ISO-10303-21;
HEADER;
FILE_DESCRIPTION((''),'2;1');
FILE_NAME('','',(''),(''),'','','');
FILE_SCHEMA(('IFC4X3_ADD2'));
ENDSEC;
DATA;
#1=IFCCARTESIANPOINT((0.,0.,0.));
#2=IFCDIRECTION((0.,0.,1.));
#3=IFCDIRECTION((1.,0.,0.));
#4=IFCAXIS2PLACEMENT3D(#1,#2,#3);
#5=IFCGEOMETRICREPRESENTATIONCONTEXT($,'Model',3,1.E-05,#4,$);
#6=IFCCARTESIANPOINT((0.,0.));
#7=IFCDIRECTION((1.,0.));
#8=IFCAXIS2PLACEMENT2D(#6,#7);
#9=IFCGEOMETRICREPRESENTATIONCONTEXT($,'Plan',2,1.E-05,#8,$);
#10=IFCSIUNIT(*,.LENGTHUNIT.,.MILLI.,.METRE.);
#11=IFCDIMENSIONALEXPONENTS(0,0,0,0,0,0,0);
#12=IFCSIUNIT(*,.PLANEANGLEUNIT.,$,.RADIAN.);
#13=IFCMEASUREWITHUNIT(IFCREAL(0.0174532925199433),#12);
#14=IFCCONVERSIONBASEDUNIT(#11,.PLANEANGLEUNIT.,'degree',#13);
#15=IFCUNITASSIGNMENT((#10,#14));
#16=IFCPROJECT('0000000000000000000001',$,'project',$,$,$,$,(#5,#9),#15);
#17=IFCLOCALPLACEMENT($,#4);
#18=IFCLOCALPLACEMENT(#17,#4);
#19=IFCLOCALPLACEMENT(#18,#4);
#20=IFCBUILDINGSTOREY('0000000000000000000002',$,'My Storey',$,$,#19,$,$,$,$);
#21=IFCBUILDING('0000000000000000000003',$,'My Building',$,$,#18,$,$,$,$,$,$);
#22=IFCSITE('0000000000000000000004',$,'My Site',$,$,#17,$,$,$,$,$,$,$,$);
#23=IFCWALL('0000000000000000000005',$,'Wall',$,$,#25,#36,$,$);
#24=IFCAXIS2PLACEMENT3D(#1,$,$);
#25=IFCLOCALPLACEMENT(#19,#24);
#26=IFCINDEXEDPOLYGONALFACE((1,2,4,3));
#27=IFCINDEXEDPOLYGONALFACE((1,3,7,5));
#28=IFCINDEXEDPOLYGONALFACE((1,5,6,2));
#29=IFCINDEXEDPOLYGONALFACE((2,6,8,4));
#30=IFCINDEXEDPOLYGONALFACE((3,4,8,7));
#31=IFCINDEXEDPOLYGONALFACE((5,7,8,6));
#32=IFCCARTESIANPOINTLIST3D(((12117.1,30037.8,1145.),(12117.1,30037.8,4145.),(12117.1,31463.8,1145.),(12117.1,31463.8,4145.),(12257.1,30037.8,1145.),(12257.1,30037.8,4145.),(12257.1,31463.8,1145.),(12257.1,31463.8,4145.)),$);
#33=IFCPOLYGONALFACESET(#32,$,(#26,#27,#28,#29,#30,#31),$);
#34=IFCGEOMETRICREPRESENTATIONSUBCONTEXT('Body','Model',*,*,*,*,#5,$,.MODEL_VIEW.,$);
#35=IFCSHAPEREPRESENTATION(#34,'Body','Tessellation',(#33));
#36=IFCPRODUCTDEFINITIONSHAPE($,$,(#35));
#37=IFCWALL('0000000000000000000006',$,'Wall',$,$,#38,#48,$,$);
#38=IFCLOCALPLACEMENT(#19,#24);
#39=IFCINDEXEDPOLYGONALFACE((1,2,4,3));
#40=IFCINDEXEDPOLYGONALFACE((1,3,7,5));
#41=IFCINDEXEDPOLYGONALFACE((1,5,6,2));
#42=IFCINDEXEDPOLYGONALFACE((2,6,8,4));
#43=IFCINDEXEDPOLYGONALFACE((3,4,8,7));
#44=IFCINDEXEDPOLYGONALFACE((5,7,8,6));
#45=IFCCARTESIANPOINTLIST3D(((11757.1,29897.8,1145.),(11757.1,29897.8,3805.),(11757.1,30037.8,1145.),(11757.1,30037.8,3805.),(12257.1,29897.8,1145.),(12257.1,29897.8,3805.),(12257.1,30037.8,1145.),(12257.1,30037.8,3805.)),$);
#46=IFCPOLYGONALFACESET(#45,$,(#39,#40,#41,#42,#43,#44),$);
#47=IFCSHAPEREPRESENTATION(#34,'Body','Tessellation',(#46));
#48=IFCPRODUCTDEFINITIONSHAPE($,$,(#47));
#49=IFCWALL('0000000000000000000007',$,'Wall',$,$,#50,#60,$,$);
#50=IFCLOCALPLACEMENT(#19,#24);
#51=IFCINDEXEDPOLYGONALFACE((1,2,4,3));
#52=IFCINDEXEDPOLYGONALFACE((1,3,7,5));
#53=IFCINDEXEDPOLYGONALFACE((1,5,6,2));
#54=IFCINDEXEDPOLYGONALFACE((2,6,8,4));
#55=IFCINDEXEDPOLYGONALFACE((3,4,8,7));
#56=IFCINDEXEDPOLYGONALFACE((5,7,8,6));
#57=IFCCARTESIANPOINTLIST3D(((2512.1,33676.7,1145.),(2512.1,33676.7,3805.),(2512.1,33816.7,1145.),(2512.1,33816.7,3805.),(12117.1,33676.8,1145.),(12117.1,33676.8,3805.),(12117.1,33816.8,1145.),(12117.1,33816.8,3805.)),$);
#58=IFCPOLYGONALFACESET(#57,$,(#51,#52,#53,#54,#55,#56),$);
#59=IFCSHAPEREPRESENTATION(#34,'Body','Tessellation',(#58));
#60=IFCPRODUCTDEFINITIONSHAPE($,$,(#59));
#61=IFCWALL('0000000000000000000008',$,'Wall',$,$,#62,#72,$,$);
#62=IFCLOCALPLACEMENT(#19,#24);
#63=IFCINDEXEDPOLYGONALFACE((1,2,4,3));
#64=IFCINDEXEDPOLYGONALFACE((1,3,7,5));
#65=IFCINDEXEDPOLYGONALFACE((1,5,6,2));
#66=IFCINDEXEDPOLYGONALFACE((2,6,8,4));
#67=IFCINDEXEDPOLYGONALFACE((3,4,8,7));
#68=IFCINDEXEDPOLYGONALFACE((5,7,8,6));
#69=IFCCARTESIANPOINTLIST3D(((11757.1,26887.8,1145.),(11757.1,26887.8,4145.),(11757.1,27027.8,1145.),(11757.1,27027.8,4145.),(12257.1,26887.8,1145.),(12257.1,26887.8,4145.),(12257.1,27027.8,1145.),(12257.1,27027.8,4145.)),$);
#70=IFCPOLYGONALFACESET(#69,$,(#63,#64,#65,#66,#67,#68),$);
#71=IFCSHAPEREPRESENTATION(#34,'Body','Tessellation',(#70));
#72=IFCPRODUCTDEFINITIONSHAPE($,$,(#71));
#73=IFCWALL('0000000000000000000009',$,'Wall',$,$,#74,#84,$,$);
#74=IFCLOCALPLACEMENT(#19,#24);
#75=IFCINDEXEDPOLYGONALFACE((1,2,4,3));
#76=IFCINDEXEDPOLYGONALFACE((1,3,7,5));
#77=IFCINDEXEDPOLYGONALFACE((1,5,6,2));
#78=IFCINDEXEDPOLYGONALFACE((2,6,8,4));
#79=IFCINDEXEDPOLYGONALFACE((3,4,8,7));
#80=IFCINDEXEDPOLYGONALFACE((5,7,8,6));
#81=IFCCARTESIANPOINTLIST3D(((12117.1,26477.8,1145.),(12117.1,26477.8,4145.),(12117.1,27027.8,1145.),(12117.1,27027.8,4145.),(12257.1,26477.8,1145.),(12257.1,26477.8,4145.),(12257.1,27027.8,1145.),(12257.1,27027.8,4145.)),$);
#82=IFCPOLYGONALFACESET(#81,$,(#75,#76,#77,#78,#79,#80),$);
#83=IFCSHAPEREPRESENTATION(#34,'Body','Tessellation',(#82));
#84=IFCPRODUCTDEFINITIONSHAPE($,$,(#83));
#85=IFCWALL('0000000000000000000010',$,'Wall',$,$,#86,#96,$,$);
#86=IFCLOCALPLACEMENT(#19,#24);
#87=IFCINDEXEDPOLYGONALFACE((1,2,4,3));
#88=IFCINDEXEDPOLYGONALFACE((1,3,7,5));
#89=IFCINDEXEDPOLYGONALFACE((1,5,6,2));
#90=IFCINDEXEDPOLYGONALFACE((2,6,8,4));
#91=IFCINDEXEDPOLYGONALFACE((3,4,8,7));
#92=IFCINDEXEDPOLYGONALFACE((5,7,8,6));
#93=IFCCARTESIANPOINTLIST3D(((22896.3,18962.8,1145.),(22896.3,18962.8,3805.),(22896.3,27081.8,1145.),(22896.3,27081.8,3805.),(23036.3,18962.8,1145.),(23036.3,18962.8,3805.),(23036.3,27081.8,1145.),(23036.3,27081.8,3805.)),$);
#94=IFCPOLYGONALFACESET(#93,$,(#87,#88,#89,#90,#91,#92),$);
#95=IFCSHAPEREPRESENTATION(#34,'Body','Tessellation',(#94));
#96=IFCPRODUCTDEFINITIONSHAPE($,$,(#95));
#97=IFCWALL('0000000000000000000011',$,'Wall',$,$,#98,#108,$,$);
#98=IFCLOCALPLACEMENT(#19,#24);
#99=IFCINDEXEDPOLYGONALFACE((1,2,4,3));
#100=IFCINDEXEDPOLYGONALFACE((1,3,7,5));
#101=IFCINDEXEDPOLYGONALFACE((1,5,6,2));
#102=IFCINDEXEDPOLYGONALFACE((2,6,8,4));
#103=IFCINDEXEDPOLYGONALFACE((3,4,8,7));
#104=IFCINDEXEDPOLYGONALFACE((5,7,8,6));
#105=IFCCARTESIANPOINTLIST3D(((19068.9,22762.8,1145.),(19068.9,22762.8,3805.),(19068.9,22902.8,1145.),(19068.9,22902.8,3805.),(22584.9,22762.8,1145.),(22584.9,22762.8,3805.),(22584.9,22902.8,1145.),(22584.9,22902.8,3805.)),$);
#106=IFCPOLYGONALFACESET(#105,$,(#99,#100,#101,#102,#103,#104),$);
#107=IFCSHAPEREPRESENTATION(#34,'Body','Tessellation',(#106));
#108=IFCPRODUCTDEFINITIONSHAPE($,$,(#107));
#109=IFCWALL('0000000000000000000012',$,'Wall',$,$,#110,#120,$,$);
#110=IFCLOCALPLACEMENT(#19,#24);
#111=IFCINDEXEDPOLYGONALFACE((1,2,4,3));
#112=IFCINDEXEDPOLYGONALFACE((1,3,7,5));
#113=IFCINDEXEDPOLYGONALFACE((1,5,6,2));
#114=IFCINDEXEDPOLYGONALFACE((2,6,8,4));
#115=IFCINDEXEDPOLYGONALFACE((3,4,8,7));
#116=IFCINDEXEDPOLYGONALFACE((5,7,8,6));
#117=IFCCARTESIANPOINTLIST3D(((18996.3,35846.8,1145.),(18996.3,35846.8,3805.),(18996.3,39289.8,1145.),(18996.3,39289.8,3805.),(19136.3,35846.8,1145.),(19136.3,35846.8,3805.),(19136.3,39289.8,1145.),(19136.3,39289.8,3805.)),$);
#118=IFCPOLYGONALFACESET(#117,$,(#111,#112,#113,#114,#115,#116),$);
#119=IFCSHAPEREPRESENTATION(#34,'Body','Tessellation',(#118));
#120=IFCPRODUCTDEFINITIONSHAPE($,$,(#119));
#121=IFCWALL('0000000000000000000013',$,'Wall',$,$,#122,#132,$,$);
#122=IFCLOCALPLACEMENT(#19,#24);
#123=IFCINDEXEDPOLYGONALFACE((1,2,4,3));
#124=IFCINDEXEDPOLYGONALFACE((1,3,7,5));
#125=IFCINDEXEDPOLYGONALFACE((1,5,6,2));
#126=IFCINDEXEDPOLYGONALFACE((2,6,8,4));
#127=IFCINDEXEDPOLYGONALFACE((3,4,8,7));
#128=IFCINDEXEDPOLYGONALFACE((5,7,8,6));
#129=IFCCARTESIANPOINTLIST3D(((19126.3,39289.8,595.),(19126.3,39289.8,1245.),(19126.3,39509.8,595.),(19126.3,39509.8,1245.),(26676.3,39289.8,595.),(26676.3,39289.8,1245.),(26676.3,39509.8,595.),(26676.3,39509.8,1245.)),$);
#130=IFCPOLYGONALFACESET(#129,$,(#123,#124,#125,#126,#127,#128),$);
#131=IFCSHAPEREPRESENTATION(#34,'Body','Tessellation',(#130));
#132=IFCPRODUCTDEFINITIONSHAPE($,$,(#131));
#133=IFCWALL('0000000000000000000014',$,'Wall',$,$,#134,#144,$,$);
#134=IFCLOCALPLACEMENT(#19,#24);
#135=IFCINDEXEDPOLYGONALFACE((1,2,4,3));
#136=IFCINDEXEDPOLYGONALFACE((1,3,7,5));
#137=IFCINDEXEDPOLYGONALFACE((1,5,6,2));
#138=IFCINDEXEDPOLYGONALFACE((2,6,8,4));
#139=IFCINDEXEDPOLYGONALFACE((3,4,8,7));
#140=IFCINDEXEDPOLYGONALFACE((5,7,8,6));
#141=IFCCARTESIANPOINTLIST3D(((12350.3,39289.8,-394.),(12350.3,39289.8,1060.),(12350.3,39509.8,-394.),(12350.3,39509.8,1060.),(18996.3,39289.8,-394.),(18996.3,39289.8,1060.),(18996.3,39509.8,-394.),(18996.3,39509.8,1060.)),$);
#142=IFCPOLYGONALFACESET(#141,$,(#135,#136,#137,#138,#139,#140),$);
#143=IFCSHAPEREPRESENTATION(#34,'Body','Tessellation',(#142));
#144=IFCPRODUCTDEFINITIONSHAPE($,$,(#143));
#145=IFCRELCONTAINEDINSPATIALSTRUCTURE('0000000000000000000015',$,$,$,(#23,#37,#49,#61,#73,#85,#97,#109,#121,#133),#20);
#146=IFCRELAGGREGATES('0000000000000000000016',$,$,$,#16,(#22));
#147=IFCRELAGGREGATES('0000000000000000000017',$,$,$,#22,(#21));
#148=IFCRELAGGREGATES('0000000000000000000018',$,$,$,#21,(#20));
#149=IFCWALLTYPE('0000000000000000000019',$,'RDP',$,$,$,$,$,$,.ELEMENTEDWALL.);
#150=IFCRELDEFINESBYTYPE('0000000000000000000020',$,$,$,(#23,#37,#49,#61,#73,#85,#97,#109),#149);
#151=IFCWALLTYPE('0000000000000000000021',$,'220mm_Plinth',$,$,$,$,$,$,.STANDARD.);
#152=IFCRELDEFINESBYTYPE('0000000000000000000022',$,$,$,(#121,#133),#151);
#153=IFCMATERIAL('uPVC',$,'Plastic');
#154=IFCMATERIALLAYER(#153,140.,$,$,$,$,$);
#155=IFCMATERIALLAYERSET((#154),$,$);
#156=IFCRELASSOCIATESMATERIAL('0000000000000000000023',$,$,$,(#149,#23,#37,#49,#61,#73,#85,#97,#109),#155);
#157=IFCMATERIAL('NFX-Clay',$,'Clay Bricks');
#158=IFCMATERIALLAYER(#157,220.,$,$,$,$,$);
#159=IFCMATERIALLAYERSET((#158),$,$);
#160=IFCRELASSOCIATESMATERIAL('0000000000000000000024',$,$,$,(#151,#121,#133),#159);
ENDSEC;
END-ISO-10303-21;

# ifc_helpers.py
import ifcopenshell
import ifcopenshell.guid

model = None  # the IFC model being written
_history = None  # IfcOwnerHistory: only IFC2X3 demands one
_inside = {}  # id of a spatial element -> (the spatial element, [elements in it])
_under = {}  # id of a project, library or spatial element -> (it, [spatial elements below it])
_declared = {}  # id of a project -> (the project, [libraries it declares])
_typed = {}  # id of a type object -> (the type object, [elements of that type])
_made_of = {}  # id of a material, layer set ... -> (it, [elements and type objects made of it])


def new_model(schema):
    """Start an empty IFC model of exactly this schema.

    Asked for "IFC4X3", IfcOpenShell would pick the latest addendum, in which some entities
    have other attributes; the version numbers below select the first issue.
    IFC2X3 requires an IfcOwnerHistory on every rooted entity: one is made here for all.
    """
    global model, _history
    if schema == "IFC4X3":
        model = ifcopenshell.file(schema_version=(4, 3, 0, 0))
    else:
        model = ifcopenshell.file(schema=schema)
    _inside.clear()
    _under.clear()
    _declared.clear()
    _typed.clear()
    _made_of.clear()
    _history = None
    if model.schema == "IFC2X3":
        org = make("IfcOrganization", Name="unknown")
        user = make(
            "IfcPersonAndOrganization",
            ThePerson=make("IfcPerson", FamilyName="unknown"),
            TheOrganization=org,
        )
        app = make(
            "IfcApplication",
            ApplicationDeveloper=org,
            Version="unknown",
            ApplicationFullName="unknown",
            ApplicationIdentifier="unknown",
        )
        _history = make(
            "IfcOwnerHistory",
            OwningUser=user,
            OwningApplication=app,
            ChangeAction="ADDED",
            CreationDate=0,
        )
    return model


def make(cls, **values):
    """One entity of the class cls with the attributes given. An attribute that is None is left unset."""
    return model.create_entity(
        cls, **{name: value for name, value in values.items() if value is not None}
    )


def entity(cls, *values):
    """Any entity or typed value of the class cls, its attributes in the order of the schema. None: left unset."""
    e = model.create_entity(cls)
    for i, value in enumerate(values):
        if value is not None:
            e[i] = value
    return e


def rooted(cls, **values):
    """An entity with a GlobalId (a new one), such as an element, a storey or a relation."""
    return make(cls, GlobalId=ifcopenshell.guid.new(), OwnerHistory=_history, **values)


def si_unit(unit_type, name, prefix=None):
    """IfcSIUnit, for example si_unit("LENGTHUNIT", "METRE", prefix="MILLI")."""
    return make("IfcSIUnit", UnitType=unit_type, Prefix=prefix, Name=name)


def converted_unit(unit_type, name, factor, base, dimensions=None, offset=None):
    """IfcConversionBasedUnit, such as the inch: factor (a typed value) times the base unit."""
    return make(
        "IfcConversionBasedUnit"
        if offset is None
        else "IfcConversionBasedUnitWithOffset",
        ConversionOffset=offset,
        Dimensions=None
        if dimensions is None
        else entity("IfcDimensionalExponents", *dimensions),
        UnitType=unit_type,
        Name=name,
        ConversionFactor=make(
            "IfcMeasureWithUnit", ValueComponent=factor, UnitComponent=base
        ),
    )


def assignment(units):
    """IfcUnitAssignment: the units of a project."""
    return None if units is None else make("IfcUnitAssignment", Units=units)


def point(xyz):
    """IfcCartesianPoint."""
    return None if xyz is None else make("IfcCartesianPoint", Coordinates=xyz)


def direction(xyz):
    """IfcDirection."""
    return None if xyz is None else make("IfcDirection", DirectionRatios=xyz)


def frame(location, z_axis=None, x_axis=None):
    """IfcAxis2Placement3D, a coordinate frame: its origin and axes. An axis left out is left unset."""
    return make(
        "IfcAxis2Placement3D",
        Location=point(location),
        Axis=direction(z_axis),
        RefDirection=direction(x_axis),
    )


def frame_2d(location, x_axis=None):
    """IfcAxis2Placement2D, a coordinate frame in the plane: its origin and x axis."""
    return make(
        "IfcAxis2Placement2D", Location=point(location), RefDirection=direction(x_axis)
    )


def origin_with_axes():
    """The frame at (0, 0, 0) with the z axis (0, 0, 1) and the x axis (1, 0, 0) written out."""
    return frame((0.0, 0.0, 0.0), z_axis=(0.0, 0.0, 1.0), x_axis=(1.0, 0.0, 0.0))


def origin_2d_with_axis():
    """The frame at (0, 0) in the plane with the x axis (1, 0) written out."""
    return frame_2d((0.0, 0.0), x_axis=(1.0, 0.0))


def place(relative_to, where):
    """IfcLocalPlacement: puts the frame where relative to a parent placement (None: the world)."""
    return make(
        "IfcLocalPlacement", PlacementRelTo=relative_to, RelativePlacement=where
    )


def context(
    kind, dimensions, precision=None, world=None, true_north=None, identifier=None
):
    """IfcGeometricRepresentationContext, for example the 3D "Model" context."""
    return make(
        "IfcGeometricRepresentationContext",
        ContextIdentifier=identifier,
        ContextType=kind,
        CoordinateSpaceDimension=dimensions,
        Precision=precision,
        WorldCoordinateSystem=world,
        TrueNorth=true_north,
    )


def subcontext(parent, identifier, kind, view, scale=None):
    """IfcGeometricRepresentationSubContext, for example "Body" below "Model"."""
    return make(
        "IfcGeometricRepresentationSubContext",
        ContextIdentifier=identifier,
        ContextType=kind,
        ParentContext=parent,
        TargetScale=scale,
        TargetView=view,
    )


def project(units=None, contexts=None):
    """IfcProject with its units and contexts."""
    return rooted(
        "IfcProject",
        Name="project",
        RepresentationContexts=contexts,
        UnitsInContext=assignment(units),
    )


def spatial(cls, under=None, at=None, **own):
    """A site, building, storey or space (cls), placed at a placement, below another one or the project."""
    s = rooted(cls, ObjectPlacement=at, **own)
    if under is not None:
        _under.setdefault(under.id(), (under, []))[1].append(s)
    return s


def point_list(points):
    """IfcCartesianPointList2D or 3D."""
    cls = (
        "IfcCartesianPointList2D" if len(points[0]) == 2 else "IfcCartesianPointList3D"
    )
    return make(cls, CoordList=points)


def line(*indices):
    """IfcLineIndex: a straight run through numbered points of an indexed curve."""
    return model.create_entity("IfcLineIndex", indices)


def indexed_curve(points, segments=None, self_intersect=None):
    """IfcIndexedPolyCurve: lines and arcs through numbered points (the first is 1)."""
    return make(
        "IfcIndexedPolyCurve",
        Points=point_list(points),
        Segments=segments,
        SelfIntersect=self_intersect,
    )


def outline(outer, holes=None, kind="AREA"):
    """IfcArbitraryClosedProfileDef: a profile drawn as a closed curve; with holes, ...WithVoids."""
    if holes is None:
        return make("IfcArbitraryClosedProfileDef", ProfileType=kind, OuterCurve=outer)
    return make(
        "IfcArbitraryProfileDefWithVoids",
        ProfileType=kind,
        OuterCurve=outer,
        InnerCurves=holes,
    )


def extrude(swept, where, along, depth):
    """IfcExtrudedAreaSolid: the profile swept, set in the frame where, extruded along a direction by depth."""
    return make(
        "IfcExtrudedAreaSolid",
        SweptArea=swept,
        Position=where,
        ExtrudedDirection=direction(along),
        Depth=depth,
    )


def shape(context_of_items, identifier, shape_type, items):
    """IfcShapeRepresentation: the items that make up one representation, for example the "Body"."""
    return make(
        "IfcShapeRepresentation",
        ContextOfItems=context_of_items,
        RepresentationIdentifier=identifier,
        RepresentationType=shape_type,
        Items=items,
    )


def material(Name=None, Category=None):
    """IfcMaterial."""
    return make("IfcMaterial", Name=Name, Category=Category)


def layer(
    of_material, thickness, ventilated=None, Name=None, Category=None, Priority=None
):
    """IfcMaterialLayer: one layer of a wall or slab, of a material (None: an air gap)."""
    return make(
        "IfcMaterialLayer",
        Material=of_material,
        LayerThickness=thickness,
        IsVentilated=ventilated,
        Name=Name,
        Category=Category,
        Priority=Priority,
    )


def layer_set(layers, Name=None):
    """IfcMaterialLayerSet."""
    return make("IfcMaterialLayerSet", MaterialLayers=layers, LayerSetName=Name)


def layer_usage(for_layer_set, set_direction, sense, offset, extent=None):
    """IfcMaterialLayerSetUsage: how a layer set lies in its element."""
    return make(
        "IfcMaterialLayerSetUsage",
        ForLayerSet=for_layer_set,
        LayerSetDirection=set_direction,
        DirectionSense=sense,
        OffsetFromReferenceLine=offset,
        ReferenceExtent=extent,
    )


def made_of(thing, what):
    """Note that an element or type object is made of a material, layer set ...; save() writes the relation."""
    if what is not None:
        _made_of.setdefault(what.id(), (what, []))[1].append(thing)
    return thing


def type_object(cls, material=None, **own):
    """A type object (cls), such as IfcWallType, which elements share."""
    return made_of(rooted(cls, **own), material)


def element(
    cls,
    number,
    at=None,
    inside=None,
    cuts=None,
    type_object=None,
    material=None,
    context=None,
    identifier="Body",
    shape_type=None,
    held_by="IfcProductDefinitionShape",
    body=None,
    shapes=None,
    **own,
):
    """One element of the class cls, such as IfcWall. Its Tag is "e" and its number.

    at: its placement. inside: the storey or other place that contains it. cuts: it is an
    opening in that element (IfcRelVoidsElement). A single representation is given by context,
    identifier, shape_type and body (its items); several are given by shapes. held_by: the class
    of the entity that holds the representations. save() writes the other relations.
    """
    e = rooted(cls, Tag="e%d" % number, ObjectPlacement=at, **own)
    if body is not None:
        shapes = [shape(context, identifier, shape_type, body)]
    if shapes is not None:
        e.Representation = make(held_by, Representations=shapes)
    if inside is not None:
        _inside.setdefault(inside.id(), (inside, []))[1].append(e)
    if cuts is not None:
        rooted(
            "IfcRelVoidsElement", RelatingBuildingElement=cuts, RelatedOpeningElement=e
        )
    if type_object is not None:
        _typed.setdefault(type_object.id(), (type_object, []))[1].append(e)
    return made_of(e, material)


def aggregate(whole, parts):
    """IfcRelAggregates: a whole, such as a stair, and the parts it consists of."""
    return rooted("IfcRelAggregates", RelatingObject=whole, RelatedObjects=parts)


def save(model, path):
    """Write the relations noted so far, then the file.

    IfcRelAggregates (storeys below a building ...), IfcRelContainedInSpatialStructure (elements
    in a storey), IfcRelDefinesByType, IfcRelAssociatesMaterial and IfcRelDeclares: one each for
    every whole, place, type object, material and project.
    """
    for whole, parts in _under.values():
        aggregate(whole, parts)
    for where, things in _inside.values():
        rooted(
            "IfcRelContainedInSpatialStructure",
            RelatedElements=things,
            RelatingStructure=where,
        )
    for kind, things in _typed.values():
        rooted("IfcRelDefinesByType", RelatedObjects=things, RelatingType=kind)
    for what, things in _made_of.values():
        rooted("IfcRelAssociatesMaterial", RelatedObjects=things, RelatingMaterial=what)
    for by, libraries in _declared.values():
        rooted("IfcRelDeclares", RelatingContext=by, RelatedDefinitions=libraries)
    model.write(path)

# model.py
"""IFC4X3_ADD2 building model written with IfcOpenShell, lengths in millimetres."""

from ifc_helpers import new_model, entity, si_unit, converted_unit, frame, origin_with_axes, origin_2d_with_axis, place, context, subcontext, project, spatial, line, indexed_curve, outline, extrude, material, layer, layer_set, layer_usage, type_object, element, save


model = new_model("IFC4X3_ADD2")

# Units and contexts
model_context = context("Model", 3, precision=1e-05, world=origin_with_axes())
plan_context = context("Plan", 2, precision=1e-05, world=origin_2d_with_axis())
body_context_1 = subcontext(model_context, "Body", "Model", "MODEL_VIEW")
ifc_project = project(units=[si_unit("LENGTHUNIT", "METRE", prefix="MILLI"), converted_unit("PLANEANGLEUNIT", "degree", entity("IfcReal", 0.0174532925199433), si_unit("PLANEANGLEUNIT", "RADIAN"), dimensions=[0, 0, 0, 0, 0, 0, 0])], contexts=[model_context, plan_context])

# Site, building, storey
site_placement = place(None, origin_with_axes())
site = spatial("IfcSite", under=ifc_project, at=site_placement, Name="My Site")
building_placement = place(site_placement, origin_with_axes())
building = spatial("IfcBuilding", under=site, at=building_placement, Name="My Building")
storey_placement = place(building_placement, origin_with_axes())
storey = spatial("IfcBuildingStorey", under=building, at=storey_placement, Name="My Storey")

# Shared definitions
ifc_material_1 = material(Name="uPVC", Category="Plastic")
ifc_layer_1 = layer(ifc_material_1, 140.0)
ifc_layer_set_1 = layer_set([ifc_layer_1])
wall_type_1 = type_object("IfcWallType", Name="RDP", PredefinedType="ELEMENTEDWALL", material=ifc_layer_set_1)

# Walls
ifc_layer_usage_1 = layer_usage(ifc_layer_set_1, "AXIS2", "POSITIVE", 0.0)
wall_1_placement = place(storey_placement, frame((12257.1, 30037.8, 1145.0), z_axis=(0.0, 0.0, 1.0), x_axis=(-0.000004, 1.0, 0.0)))
element("IfcWall", 1, at=wall_1_placement, inside=storey, type_object=wall_type_1, material=ifc_layer_usage_1, Name="Wall", context=body_context_1, shape_type="SweptSolid", body=[
    extrude(outline(indexed_curve([(0.0, 0.0), (0.0, 140.0), (1426.0, 140.0), (1426.0, 0.0)], segments=[line(1, 2, 3, 4, 1)])), origin_with_axes(), (0.0, 0.0, 1.0), 3000.0),
])
ifc_layer_usage_2 = layer_usage(ifc_layer_set_1, "AXIS2", "POSITIVE", 0.0)
wall_2_placement = place(storey_placement, frame((12257.1, 30037.8, 1145.0), z_axis=(0.0, 0.0, 1.0), x_axis=(-1.0, -0.000004, 0.0)))
element("IfcWall", 2, at=wall_2_placement, inside=storey, type_object=wall_type_1, material=ifc_layer_usage_2, Name="Wall", context=body_context_1, shape_type="SweptSolid", body=[
    extrude(outline(indexed_curve([(0.0, 0.0), (0.0, 140.0), (500.0, 140.0), (500.0, 0.0)], segments=[line(1, 2, 3, 4, 1)])), origin_with_axes(), (0.0, 0.0, 1.0), 2660.0),
])
ifc_layer_usage_3 = layer_usage(ifc_layer_set_1, "AXIS2", "POSITIVE", 0.0)
wall_3_placement = place(storey_placement, frame((12117.1, 33816.8, 1145.0), z_axis=(0.0, 0.0, 1.0), x_axis=(-1.0, -0.000004, 0.0)))
element("IfcWall", 3, at=wall_3_placement, inside=storey, type_object=wall_type_1, material=ifc_layer_usage_3, Name="Wall", context=body_context_1, shape_type="SweptSolid", body=[
    extrude(outline(indexed_curve([(0.0, 0.0), (0.0, 140.0), (9605.0, 140.0), (9605.0, 0.0)], segments=[line(1, 2, 3, 4, 1)])), origin_with_axes(), (0.0, 0.0, 1.0), 2660.0),
])
ifc_layer_usage_4 = layer_usage(ifc_layer_set_1, "AXIS2", "POSITIVE", 0.0)
wall_4_placement = place(storey_placement, frame((12257.1, 27027.8, 1145.0), z_axis=(0.0, 0.0, 1.0), x_axis=(-1.0, -0.000004, 0.0)))
element("IfcWall", 4, at=wall_4_placement, inside=storey, type_object=wall_type_1, material=ifc_layer_usage_4, Name="Wall", context=body_context_1, shape_type="SweptSolid", body=[
    extrude(outline(indexed_curve([(0.0, 0.0), (0.0, 140.0), (500.0, 140.0), (500.0, 0.0)], segments=[line(1, 2, 3, 4, 1)])), origin_with_axes(), (0.0, 0.0, 1.0), 3000.0),
])
ifc_layer_usage_5 = layer_usage(ifc_layer_set_1, "AXIS2", "POSITIVE", 0.0)
wall_5_placement = place(storey_placement, frame((12117.1, 27027.8, 1145.0), z_axis=(0.0, 0.0, 1.0), x_axis=(0.000004, -1.0, 0.0)))
element("IfcWall", 5, at=wall_5_placement, inside=storey, type_object=wall_type_1, material=ifc_layer_usage_5, Name="Wall", context=body_context_1, shape_type="SweptSolid", body=[
    extrude(outline(indexed_curve([(0.0, 0.0), (0.0, 140.0), (550.0, 140.0), (550.0, 0.0)], segments=[line(1, 2, 3, 4, 1)])), origin_with_axes(), (0.0, 0.0, 1.0), 3000.0),
])

# Walls
ifc_layer_usage_6 = layer_usage(ifc_layer_set_1, "AXIS2", "NEGATIVE", 0.0)
wall_6_placement = place(storey_placement, frame((23036.3, 27081.8, 1145.0), z_axis=(0.0, 0.0, 1.0), x_axis=(0.000002, -1.0, 0.0)))
element("IfcWall", 6, at=wall_6_placement, inside=storey, type_object=wall_type_1, material=ifc_layer_usage_6, Name="Wall", context=body_context_1, shape_type="SweptSolid", body=[
    extrude(outline(indexed_curve([(0.0, -140.0), (0.0, 0.0), (8119.0, 0.0), (8119.0, -140.0)], segments=[line(1, 2, 3, 4, 1)])), origin_with_axes(), (0.0, 0.0, 1.0), 2660.0),
])
ifc_layer_usage_7 = layer_usage(ifc_layer_set_1, "AXIS2", "POSITIVE", 0.0)
wall_7_placement = place(storey_placement, frame((19068.9, 22762.8, 1145.0), z_axis=(0.0, 0.0, 1.0), x_axis=(1.0, 0.000001, 0.0)))
element("IfcWall", 7, at=wall_7_placement, inside=storey, type_object=wall_type_1, material=ifc_layer_usage_7, Name="Wall", context=body_context_1, shape_type="SweptSolid", body=[
    extrude(outline(indexed_curve([(0.0, 0.0), (0.0, 140.0), (3516.0, 140.0), (3516.0, 0.0)], segments=[line(1, 2, 3, 4, 1)])), origin_with_axes(), (0.0, 0.0, 1.0), 2660.0),
])
ifc_layer_usage_8 = layer_usage(ifc_layer_set_1, "AXIS2", "NEGATIVE", 0.0)
wall_8_placement = place(storey_placement, frame((19136.3, 39289.8, 1145.0), z_axis=(0.0, 0.0, 1.0), x_axis=(0.000002, -1.0, 0.0)))
element("IfcWall", 8, at=wall_8_placement, inside=storey, type_object=wall_type_1, material=ifc_layer_usage_8, Name="Wall", context=body_context_1, shape_type="SweptSolid", body=[
    extrude(outline(indexed_curve([(0.0, -140.0), (0.0, 0.0), (3443.0, 0.0), (3443.0, -140.0)], segments=[line(1, 2, 3, 4, 1)])), origin_with_axes(), (0.0, 0.0, 1.0), 2660.0),
])
ifc_material_2 = material(Name="NFX-Clay", Category="Clay Bricks")
ifc_layer_2 = layer(ifc_material_2, 220.0)
ifc_layer_set_2 = layer_set([ifc_layer_2])
ifc_layer_usage_9 = layer_usage(ifc_layer_set_2, "AXIS2", "POSITIVE", 0.0)
wall_type_2 = type_object("IfcWallType", Name="220mm_Plinth", PredefinedType="STANDARD", material=ifc_layer_set_2)
wall_9_placement = place(storey_placement, frame((19126.3, 39289.8, 595.0), z_axis=(0.0, 0.0, 1.0), x_axis=(1.0, 0.000002, 0.0)))
element("IfcWall", 9, at=wall_9_placement, inside=storey, type_object=wall_type_2, material=ifc_layer_usage_9, Name="Wall", context=body_context_1, shape_type="SweptSolid", body=[
    extrude(outline(indexed_curve([(0.0, 0.0), (0.0, 220.0), (7550.0, 220.0), (7550.0, 0.0)], segments=[line(1, 2, 3, 4, 1)])), origin_with_axes(), (0.0, 0.0, 1.0), 650.0),
])
ifc_layer_usage_10 = layer_usage(ifc_layer_set_2, "AXIS2", "POSITIVE", 0.0)
wall_10_placement = place(storey_placement, frame((12350.3, 39289.8, -394.0), z_axis=(0.0, 0.0, 1.0), x_axis=(1.0, 0.000002, 0.0)))
element("IfcWall", 10, at=wall_10_placement, inside=storey, type_object=wall_type_2, material=ifc_layer_usage_10, Name="Wall", context=body_context_1, shape_type="SweptSolid", body=[
    extrude(outline(indexed_curve([(0.0, 0.0), (0.0, 220.0), (6646.0, 220.0), (6646.0, 0.0)], segments=[line(1, 2, 3, 4, 1)])), origin_with_axes(), (0.0, 0.0, 1.0), 1454.0),
])

save(model, "model.ifc")
